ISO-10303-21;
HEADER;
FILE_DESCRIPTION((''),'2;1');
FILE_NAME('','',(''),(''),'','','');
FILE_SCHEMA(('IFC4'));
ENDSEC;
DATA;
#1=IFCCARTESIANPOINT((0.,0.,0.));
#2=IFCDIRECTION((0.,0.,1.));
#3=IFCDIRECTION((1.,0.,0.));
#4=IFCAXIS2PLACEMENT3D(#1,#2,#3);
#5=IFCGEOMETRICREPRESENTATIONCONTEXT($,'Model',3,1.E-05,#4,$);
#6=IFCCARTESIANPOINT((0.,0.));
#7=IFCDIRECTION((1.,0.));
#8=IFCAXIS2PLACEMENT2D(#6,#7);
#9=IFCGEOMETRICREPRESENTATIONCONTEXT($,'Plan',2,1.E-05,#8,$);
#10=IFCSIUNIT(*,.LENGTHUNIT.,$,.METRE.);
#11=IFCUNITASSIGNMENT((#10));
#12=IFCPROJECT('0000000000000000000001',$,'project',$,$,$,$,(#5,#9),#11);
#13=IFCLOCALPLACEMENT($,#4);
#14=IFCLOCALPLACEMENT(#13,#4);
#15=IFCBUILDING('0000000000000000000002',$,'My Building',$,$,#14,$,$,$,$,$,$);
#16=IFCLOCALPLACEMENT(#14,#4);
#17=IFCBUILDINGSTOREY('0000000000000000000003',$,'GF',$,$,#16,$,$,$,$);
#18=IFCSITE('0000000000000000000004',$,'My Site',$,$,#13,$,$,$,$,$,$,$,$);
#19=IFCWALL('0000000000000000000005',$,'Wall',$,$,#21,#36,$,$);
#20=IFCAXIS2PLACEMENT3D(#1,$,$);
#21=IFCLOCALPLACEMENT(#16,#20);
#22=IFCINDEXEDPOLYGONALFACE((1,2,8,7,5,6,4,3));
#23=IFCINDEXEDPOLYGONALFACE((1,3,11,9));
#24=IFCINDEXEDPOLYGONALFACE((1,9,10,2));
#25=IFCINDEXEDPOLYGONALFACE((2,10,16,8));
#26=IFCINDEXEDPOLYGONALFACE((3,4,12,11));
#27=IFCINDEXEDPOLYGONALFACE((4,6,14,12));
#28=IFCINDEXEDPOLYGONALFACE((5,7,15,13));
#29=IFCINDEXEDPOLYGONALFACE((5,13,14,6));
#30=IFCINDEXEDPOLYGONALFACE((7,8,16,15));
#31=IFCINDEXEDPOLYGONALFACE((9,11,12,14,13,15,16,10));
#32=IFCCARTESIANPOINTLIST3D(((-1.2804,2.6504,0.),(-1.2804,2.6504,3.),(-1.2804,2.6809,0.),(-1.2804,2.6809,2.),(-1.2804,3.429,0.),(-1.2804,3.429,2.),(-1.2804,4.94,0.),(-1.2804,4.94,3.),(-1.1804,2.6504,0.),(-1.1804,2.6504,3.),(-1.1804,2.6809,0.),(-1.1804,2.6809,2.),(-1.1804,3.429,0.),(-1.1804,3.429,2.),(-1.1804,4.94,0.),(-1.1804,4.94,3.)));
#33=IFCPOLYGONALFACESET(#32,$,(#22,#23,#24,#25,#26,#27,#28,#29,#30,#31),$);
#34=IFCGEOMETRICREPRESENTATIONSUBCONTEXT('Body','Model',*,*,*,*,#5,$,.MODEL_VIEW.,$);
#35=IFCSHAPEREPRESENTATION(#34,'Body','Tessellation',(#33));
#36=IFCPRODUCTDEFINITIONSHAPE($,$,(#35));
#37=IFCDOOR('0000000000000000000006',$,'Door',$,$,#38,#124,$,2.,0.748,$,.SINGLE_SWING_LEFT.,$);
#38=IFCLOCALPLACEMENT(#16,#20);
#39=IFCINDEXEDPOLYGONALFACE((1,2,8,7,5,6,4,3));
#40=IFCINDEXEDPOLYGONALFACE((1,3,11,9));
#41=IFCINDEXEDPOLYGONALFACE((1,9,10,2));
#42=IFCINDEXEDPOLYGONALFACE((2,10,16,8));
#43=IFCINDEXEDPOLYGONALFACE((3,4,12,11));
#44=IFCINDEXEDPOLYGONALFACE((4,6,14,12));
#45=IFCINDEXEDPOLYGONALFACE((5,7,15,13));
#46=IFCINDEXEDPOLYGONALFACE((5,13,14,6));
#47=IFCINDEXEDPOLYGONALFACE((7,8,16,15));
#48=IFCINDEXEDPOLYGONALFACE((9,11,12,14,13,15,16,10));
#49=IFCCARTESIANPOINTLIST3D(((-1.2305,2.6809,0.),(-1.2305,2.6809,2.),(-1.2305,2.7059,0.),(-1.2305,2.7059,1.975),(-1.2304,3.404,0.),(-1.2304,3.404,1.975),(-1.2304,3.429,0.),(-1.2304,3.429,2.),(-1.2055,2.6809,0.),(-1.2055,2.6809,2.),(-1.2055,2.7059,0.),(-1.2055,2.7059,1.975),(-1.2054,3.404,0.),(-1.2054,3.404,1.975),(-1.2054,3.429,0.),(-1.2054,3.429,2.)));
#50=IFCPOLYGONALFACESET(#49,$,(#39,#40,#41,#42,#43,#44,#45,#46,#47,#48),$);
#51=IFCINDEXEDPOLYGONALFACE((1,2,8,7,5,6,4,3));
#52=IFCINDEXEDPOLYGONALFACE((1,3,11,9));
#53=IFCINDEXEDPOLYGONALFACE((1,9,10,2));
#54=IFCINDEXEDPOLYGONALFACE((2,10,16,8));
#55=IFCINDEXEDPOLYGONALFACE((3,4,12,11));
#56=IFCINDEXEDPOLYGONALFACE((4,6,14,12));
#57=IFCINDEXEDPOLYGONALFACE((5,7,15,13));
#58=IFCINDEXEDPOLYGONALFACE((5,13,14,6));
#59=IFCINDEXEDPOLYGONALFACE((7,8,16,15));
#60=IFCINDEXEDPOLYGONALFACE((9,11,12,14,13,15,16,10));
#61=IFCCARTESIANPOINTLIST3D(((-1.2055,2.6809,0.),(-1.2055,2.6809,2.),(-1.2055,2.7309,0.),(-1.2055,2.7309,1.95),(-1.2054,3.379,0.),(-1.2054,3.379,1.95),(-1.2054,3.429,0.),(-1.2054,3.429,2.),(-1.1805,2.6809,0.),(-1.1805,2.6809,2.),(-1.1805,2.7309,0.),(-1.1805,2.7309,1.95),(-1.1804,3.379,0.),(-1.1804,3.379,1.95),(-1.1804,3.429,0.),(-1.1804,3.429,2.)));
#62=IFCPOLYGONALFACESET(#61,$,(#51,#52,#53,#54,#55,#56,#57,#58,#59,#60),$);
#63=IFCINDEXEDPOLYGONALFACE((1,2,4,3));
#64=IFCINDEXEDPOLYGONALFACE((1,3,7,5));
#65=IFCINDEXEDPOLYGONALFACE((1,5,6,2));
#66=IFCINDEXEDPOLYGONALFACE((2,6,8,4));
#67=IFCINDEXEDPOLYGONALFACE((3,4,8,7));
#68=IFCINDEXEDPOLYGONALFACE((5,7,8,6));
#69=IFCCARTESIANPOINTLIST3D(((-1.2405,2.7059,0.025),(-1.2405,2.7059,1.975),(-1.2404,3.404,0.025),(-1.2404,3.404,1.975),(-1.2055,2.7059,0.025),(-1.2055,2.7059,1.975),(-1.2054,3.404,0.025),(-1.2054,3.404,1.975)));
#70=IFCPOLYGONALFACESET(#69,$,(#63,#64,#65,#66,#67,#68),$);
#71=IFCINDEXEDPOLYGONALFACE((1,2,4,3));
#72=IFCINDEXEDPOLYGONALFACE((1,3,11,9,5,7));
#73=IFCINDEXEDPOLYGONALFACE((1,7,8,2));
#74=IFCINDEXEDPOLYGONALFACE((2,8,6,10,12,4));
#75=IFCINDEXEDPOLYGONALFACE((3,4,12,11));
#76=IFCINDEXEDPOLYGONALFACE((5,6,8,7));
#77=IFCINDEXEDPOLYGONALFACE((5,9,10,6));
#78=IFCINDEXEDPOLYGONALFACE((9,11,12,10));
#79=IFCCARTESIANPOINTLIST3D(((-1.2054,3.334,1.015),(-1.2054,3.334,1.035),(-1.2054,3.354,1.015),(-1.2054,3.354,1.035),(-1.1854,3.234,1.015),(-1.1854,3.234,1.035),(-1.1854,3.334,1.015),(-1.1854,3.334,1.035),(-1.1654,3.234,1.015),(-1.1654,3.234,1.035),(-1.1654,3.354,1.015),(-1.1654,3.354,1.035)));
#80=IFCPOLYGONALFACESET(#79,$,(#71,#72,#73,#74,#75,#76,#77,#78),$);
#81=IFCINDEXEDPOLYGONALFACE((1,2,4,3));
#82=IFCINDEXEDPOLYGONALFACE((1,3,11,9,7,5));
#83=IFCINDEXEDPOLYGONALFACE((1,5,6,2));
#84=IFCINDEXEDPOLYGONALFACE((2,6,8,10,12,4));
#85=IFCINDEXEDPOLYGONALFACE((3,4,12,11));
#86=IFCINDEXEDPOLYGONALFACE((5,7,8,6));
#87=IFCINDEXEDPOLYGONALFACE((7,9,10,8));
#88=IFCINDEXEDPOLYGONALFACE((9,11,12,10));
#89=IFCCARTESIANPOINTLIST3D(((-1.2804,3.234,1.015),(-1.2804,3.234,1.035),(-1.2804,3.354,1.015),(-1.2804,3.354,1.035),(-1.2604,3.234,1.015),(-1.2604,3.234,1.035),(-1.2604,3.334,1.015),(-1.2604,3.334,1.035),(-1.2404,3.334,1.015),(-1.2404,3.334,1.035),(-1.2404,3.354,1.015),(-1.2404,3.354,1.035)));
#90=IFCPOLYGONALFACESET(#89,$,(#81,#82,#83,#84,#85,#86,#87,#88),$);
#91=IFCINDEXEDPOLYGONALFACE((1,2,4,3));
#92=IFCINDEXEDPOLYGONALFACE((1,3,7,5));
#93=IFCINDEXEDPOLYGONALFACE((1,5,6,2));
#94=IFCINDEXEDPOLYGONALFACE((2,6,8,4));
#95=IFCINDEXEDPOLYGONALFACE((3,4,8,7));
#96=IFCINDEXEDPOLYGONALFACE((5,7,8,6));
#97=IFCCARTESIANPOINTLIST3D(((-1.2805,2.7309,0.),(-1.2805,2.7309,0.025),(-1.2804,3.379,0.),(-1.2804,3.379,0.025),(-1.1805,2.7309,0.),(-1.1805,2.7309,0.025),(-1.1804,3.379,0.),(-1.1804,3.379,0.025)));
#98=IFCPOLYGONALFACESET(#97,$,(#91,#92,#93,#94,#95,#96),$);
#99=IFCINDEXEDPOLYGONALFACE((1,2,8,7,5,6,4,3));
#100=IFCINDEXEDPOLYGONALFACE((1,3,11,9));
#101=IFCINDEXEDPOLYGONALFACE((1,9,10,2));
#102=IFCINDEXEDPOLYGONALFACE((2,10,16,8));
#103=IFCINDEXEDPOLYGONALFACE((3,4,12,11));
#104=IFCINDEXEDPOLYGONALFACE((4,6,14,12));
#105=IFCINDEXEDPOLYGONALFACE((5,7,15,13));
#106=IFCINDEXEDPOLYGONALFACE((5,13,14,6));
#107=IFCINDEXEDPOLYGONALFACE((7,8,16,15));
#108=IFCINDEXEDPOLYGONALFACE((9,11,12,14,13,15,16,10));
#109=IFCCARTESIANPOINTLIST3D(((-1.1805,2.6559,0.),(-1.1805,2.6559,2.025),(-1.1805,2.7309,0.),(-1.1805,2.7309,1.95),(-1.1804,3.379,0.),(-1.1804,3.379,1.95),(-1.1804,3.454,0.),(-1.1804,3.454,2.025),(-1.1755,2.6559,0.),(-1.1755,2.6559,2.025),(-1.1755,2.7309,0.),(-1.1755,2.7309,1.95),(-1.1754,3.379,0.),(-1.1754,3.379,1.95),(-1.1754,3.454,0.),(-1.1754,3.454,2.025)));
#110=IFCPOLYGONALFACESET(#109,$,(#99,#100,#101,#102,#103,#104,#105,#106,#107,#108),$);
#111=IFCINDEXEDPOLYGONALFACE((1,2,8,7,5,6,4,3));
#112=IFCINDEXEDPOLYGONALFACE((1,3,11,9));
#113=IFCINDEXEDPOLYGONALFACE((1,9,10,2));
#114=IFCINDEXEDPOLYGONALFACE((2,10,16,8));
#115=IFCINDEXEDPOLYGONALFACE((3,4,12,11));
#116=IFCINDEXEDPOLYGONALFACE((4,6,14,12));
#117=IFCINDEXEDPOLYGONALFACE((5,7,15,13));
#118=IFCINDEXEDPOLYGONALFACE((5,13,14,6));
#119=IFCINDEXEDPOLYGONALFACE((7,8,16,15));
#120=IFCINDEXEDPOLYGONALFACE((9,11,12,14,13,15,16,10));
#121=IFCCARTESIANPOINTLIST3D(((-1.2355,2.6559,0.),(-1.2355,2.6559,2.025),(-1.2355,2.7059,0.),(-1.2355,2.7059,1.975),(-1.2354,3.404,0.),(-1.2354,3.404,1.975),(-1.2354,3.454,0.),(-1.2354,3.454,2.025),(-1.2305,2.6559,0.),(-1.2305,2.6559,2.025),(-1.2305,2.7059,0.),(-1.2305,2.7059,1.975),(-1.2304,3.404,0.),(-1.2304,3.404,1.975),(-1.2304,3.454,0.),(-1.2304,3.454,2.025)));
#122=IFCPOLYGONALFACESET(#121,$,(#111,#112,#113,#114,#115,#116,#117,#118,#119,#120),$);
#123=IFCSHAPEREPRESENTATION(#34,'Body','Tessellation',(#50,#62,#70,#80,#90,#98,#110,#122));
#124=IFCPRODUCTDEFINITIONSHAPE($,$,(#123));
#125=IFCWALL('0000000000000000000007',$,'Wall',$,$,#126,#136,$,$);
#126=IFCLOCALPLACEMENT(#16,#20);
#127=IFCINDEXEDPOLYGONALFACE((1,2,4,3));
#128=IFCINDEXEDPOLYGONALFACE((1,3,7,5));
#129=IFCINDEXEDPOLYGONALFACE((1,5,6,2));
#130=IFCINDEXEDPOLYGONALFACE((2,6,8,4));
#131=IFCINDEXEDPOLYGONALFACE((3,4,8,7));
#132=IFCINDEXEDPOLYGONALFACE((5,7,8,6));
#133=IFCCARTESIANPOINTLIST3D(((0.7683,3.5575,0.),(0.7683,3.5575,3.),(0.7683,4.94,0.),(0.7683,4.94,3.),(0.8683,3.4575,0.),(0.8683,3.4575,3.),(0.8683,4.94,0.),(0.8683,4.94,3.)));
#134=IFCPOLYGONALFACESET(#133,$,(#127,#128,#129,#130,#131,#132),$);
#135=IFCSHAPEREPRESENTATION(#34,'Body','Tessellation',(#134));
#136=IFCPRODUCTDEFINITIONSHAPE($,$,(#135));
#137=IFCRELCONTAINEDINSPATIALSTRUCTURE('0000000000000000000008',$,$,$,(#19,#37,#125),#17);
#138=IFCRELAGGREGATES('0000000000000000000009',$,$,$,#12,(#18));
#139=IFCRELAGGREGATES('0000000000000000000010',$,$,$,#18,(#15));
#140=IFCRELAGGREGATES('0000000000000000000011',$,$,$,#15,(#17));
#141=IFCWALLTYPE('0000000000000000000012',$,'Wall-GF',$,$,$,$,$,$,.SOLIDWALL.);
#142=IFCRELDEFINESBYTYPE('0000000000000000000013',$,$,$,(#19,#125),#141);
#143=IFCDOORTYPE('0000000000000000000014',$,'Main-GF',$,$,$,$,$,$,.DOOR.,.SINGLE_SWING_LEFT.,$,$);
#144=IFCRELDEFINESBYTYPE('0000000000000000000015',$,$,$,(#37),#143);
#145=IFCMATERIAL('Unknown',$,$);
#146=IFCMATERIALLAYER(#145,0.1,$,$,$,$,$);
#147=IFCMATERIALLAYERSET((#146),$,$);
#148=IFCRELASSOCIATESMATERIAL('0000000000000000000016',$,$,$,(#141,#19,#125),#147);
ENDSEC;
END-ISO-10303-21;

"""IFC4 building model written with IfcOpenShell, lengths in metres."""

from ifc_helpers import new_model, entity, si_unit, frame, origin_with_axes, origin_2d_with_axis, place, context, subcontext, project, spatial, line, indexed_curve, outline, extrude, shape, source, transform, mapped, material, layer, layer_set, layer_usage, type_object, type_shapes, element, fill, save


model = new_model("IFC4")

# Units and contexts
model_context = context("Model", 3, precision=1e-05, world=origin_with_axes())
plan_context = context("Plan", 2, precision=1e-05, world=origin_2d_with_axis())
body_context_1 = subcontext(model_context, "Body", "Model", "MODEL_VIEW")
body_context_2 = subcontext(plan_context, "Body", "Plan", "PLAN_VIEW")
ifc_project = project(units=[si_unit("LENGTHUNIT", "METRE")], contexts=[model_context, plan_context])

# Site, building, storey
site_placement = place(None, origin_with_axes())
site = spatial("IfcSite", under=ifc_project, at=site_placement, Name="My Site")
building_placement = place(site_placement, origin_with_axes())
building = spatial("IfcBuilding", under=site, at=building_placement, Name="My Building")
storey_placement = place(building_placement, origin_with_axes())
storey = spatial("IfcBuildingStorey", under=building, at=storey_placement, Name="GF")

# Shared definitions
ifc_material_1 = material(Name="Unknown")

# Shared definitions
ifc_layer_1 = layer(ifc_material_1, 0.1)
ifc_layer_set_1 = layer_set([ifc_layer_1])
wall_type = type_object("IfcWallType", Name="Wall-GF", PredefinedType="SOLIDWALL", material=ifc_layer_set_1)
shared_shape_1 = source(origin_with_axes(), body_context_1, "Body", "SweptSolid", [
    extrude(outline(indexed_curve([(0.0, 0.0), (0.748, 0.0), (0.748, 2.0), (0.0, 2.0)], segments=[line(1, 2, 3, 4, 1)])), frame((0.0, -0.6, 0.0), z_axis=(0.0, -1.0, 0.0), x_axis=(1.0, 0.0, 0.0)), (0.0, 0.0, -1.0), 1.2),
])
door_type_1 = type_object("IfcDoorType", Name="Main-GF", OperationType="SINGLE_SWING_LEFT", PredefinedType="DOOR")
shared_shape_2 = source(origin_with_axes(), body_context_1, "Body", "SweptSolid", [
    extrude(outline(indexed_curve([(0.0, 0.0), (0.0, 2.0), (0.748, 2.0), (0.748, 0.0), (0.723, 0.0), (0.723, 1.975), (0.025, 1.975), (0.025, 0.0)], segments=[line(1, 2, 3, 4, 5, 6, 7, 8, 1)])), frame((0.0, 0.025, 0.0), z_axis=(0.0, -1.0, 0.0), x_axis=(1.0, 0.0, 0.0)), (0.0, 0.0, -1.0), 0.025),
    extrude(outline(indexed_curve([(0.0, 0.0), (0.0, 2.0), (0.748, 2.0), (0.748, 0.0), (0.698, 0.0), (0.698, 1.95), (0.05, 1.95), (0.05, 0.0)], segments=[line(1, 2, 3, 4, 5, 6, 7, 8, 1)])), frame((0.0, 0.0, 0.0), z_axis=(0.0, -1.0, 0.0), x_axis=(1.0, 0.0, 0.0)), (0.0, 0.0, -1.0), 0.025),
    extrude(outline(indexed_curve([(0.0, 0.0), (0.698, 0.0), (0.698, 0.035), (0.0, 0.035)], segments=[line(1, 2, 3, 4, 1)])), frame((0.025, 0.025, 0.025), z_axis=(0.0, 0.0, 1.0), x_axis=(1.0, 0.0, 0.0)), (0.0, 0.0, 1.0), 1.95),
    extrude(outline(indexed_curve([(0.0, 0.0), (0.0, -0.04), (-0.12, -0.04), (-0.12, -0.02), (-0.02, -0.02), (-0.02, 0.0)], segments=[line(1, 2, 3, 4, 5, 6, 1)])), frame((0.673, 0.025, 1.015), z_axis=(0.0, 0.0, 1.0), x_axis=(1.0, 0.0, 0.0)), (0.0, 0.0, 1.0), 0.02),
    extrude(outline(indexed_curve([(0.0, 0.0), (0.0, 0.04), (-0.12, 0.04), (-0.12, 0.02), (-0.02, 0.02), (-0.02, 0.0)], segments=[line(1, 2, 3, 4, 5, 6, 1)])), frame((0.673, 0.06, 1.015), z_axis=(0.0, 0.0, 1.0), x_axis=(1.0, 0.0, 0.0)), (0.0, 0.0, 1.0), 0.02),
    extrude(outline(indexed_curve([(0.0, 0.0), (0.648, 0.0), (0.648, 0.1), (0.0, 0.1)], segments=[line(1, 2, 3, 4, 1)])), frame((0.05, 0.0, 0.0), z_axis=(0.0, 0.0, 1.0), x_axis=(1.0, 0.0, 0.0)), (0.0, 0.0, 1.0), 0.025),
    extrude(outline(indexed_curve([(0.0, 0.0), (0.0, 2.025), (0.798, 2.025), (0.798, 0.0), (0.723, 0.0), (0.723, 1.95), (0.075, 1.95), (0.075, 0.0)], segments=[line(1, 2, 3, 4, 5, 6, 7, 8, 1)])), frame((-0.025, -0.005, 0.0), z_axis=(0.0, -1.0, 0.0), x_axis=(1.0, 0.0, 0.0)), (0.0, 0.0, -1.0), 0.005),
    extrude(outline(indexed_curve([(0.0, 0.0), (0.0, 2.025), (0.798, 2.025), (0.798, 0.0), (0.748, 0.0), (0.748, 1.975), (0.05, 1.975), (0.05, 0.0)], segments=[line(1, 2, 3, 4, 5, 6, 7, 8, 1)])), frame((-0.025, 0.05, 0.0), z_axis=(0.0, -1.0, 0.0), x_axis=(1.0, 0.0, 0.0)), (0.0, 0.0, -1.0), 0.005),
])
shared_shape_3 = source(origin_with_axes(), body_context_2, "Body", "Curve2D", [
    entity("IfcIndexedPolyCurve", entity("IfcCartesianPointList2D", [[0.0, 0.0], [0.0, 0.05], [0.025, 0.05], [0.025, 0.025], [0.05, 0.025], [0.05, 0.0]]), [entity("IfcLineIndex", [1, 2, 3, 4, 5, 6, 1])]),
    entity("IfcIndexedPolyCurve", entity("IfcCartesianPointList2D", [[0.748, 0.0], [0.748, 0.05], [0.723, 0.05], [0.723, 0.025], [0.698, 0.025], [0.698, 0.0]]), [entity("IfcLineIndex", [1, 2, 3, 4, 5, 6, 1])]),
    entity("IfcTrimmedCurve", entity("IfcEllipse", entity("IfcAxis2Placement2D", entity("IfcCartesianPoint", [0.06, 0.05]), entity("IfcDirection", [1.0, 0.0])), 0.663, 0.698), [entity("IfcCartesianPoint", [0.723, 0.05])], [entity("IfcCartesianPoint", [0.06, 0.748])], True, "CARTESIAN"),
    entity("IfcIndexedPolyCurve", entity("IfcCartesianPointList2D", [[0.025, 0.05], [0.06, 0.05], [0.06, 0.748], [0.025, 0.748]]), [entity("IfcLineIndex", [1, 2, 3, 4, 1])]),
])
type_shapes(door_type_1, [shared_shape_2, shared_shape_3])

# Wall, opening, door
ifc_layer_usage_1 = layer_usage(ifc_layer_set_1, "AXIS2", "POSITIVE", 0.0)
wall_1_placement = place(storey_placement, frame((-1.1804, 2.6504, 0.0), z_axis=(0.0, 0.0, 1.0), x_axis=(0.0, 1.0, 0.0)))
wall_1 = element("IfcWall", 1, at=wall_1_placement, inside=storey, type_object=wall_type, material=ifc_layer_usage_1, Name="Wall", context=body_context_1, shape_type="SweptSolid", body=[
    extrude(outline(indexed_curve([(0.0, 0.0), (0.0, 0.1), (2.2896, 0.1), (2.2896, 0.0)], segments=[line(1, 2, 3, 4, 1)])), origin_with_axes(), (0.0, 0.0, 1.0), 3.0),
])
opening_1_placement = place(wall_1_placement, frame((0.0306, 0.0, 0.0), z_axis=(0.0, 0.0, 1.0), x_axis=(1.0, 0.0, 0.0)))
opening_1 = element("IfcOpeningElement", 2, at=opening_1_placement, cuts=wall_1, PredefinedType="OPENING", context=body_context_1, shape_type="MappedRepresentation", body=[
    mapped(shared_shape_1, transform((0.0, 0.0, 0.0), x_axis=(1.0, 0.0, 0.0), y_axis=(0.0, 1.0, 0.0), z_axis=(0.0, 0.0, 1.0), scale=1.0)),
])
door_1_placement = place(opening_1_placement, frame((0.0, 0.0, 0.0), z_axis=(0.0, 0.0, 1.0), x_axis=(1.0, 0.0, 0.0)))
door_1 = element("IfcDoor", 3, at=door_1_placement, inside=storey, type_object=door_type_1, Name="Door", OperationType="SINGLE_SWING_LEFT", OverallHeight=2.0, OverallWidth=0.748, shapes=[
    shape(body_context_1, "Body", "MappedRepresentation", [mapped(shared_shape_2, transform((0.0, 0.0, 0.0), x_axis=(1.0, 0.0, 0.0), y_axis=(0.0, 1.0, 0.0), z_axis=(0.0, 0.0, 1.0), scale=1.0))]),
    shape(body_context_2, "Body", "MappedRepresentation", [mapped(shared_shape_3, transform((0.0, 0.0, 0.0), x_axis=(1.0, 0.0, 0.0), y_axis=(0.0, 1.0, 0.0), z_axis=(0.0, 0.0, 1.0), scale=1.0))]),
])
fill(opening_1, door_1)

# Wall
ifc_layer_usage_2 = layer_usage(ifc_layer_set_1, "AXIS2", "POSITIVE", 0.0)
wall_2_placement = place(storey_placement, frame((0.7683, 5.04, 0.0), z_axis=(0.0, 0.0, 1.0), x_axis=(0.0, -1.0, 0.0)))
element("IfcWall", 4, at=wall_2_placement, inside=storey, type_object=wall_type, material=ifc_layer_usage_2, Name="Wall", context=body_context_1, shape_type="SweptSolid", body=[
    extrude(outline(indexed_curve([(0.1, 0.0), (0.1, 0.1), (1.5825, 0.1), (1.4825, 0.0)], segments=[line(1, 2, 3, 4, 1)])), origin_with_axes(), (0.0, 0.0, 1.0), 3.0),
])

save(model, "model.ifc")
